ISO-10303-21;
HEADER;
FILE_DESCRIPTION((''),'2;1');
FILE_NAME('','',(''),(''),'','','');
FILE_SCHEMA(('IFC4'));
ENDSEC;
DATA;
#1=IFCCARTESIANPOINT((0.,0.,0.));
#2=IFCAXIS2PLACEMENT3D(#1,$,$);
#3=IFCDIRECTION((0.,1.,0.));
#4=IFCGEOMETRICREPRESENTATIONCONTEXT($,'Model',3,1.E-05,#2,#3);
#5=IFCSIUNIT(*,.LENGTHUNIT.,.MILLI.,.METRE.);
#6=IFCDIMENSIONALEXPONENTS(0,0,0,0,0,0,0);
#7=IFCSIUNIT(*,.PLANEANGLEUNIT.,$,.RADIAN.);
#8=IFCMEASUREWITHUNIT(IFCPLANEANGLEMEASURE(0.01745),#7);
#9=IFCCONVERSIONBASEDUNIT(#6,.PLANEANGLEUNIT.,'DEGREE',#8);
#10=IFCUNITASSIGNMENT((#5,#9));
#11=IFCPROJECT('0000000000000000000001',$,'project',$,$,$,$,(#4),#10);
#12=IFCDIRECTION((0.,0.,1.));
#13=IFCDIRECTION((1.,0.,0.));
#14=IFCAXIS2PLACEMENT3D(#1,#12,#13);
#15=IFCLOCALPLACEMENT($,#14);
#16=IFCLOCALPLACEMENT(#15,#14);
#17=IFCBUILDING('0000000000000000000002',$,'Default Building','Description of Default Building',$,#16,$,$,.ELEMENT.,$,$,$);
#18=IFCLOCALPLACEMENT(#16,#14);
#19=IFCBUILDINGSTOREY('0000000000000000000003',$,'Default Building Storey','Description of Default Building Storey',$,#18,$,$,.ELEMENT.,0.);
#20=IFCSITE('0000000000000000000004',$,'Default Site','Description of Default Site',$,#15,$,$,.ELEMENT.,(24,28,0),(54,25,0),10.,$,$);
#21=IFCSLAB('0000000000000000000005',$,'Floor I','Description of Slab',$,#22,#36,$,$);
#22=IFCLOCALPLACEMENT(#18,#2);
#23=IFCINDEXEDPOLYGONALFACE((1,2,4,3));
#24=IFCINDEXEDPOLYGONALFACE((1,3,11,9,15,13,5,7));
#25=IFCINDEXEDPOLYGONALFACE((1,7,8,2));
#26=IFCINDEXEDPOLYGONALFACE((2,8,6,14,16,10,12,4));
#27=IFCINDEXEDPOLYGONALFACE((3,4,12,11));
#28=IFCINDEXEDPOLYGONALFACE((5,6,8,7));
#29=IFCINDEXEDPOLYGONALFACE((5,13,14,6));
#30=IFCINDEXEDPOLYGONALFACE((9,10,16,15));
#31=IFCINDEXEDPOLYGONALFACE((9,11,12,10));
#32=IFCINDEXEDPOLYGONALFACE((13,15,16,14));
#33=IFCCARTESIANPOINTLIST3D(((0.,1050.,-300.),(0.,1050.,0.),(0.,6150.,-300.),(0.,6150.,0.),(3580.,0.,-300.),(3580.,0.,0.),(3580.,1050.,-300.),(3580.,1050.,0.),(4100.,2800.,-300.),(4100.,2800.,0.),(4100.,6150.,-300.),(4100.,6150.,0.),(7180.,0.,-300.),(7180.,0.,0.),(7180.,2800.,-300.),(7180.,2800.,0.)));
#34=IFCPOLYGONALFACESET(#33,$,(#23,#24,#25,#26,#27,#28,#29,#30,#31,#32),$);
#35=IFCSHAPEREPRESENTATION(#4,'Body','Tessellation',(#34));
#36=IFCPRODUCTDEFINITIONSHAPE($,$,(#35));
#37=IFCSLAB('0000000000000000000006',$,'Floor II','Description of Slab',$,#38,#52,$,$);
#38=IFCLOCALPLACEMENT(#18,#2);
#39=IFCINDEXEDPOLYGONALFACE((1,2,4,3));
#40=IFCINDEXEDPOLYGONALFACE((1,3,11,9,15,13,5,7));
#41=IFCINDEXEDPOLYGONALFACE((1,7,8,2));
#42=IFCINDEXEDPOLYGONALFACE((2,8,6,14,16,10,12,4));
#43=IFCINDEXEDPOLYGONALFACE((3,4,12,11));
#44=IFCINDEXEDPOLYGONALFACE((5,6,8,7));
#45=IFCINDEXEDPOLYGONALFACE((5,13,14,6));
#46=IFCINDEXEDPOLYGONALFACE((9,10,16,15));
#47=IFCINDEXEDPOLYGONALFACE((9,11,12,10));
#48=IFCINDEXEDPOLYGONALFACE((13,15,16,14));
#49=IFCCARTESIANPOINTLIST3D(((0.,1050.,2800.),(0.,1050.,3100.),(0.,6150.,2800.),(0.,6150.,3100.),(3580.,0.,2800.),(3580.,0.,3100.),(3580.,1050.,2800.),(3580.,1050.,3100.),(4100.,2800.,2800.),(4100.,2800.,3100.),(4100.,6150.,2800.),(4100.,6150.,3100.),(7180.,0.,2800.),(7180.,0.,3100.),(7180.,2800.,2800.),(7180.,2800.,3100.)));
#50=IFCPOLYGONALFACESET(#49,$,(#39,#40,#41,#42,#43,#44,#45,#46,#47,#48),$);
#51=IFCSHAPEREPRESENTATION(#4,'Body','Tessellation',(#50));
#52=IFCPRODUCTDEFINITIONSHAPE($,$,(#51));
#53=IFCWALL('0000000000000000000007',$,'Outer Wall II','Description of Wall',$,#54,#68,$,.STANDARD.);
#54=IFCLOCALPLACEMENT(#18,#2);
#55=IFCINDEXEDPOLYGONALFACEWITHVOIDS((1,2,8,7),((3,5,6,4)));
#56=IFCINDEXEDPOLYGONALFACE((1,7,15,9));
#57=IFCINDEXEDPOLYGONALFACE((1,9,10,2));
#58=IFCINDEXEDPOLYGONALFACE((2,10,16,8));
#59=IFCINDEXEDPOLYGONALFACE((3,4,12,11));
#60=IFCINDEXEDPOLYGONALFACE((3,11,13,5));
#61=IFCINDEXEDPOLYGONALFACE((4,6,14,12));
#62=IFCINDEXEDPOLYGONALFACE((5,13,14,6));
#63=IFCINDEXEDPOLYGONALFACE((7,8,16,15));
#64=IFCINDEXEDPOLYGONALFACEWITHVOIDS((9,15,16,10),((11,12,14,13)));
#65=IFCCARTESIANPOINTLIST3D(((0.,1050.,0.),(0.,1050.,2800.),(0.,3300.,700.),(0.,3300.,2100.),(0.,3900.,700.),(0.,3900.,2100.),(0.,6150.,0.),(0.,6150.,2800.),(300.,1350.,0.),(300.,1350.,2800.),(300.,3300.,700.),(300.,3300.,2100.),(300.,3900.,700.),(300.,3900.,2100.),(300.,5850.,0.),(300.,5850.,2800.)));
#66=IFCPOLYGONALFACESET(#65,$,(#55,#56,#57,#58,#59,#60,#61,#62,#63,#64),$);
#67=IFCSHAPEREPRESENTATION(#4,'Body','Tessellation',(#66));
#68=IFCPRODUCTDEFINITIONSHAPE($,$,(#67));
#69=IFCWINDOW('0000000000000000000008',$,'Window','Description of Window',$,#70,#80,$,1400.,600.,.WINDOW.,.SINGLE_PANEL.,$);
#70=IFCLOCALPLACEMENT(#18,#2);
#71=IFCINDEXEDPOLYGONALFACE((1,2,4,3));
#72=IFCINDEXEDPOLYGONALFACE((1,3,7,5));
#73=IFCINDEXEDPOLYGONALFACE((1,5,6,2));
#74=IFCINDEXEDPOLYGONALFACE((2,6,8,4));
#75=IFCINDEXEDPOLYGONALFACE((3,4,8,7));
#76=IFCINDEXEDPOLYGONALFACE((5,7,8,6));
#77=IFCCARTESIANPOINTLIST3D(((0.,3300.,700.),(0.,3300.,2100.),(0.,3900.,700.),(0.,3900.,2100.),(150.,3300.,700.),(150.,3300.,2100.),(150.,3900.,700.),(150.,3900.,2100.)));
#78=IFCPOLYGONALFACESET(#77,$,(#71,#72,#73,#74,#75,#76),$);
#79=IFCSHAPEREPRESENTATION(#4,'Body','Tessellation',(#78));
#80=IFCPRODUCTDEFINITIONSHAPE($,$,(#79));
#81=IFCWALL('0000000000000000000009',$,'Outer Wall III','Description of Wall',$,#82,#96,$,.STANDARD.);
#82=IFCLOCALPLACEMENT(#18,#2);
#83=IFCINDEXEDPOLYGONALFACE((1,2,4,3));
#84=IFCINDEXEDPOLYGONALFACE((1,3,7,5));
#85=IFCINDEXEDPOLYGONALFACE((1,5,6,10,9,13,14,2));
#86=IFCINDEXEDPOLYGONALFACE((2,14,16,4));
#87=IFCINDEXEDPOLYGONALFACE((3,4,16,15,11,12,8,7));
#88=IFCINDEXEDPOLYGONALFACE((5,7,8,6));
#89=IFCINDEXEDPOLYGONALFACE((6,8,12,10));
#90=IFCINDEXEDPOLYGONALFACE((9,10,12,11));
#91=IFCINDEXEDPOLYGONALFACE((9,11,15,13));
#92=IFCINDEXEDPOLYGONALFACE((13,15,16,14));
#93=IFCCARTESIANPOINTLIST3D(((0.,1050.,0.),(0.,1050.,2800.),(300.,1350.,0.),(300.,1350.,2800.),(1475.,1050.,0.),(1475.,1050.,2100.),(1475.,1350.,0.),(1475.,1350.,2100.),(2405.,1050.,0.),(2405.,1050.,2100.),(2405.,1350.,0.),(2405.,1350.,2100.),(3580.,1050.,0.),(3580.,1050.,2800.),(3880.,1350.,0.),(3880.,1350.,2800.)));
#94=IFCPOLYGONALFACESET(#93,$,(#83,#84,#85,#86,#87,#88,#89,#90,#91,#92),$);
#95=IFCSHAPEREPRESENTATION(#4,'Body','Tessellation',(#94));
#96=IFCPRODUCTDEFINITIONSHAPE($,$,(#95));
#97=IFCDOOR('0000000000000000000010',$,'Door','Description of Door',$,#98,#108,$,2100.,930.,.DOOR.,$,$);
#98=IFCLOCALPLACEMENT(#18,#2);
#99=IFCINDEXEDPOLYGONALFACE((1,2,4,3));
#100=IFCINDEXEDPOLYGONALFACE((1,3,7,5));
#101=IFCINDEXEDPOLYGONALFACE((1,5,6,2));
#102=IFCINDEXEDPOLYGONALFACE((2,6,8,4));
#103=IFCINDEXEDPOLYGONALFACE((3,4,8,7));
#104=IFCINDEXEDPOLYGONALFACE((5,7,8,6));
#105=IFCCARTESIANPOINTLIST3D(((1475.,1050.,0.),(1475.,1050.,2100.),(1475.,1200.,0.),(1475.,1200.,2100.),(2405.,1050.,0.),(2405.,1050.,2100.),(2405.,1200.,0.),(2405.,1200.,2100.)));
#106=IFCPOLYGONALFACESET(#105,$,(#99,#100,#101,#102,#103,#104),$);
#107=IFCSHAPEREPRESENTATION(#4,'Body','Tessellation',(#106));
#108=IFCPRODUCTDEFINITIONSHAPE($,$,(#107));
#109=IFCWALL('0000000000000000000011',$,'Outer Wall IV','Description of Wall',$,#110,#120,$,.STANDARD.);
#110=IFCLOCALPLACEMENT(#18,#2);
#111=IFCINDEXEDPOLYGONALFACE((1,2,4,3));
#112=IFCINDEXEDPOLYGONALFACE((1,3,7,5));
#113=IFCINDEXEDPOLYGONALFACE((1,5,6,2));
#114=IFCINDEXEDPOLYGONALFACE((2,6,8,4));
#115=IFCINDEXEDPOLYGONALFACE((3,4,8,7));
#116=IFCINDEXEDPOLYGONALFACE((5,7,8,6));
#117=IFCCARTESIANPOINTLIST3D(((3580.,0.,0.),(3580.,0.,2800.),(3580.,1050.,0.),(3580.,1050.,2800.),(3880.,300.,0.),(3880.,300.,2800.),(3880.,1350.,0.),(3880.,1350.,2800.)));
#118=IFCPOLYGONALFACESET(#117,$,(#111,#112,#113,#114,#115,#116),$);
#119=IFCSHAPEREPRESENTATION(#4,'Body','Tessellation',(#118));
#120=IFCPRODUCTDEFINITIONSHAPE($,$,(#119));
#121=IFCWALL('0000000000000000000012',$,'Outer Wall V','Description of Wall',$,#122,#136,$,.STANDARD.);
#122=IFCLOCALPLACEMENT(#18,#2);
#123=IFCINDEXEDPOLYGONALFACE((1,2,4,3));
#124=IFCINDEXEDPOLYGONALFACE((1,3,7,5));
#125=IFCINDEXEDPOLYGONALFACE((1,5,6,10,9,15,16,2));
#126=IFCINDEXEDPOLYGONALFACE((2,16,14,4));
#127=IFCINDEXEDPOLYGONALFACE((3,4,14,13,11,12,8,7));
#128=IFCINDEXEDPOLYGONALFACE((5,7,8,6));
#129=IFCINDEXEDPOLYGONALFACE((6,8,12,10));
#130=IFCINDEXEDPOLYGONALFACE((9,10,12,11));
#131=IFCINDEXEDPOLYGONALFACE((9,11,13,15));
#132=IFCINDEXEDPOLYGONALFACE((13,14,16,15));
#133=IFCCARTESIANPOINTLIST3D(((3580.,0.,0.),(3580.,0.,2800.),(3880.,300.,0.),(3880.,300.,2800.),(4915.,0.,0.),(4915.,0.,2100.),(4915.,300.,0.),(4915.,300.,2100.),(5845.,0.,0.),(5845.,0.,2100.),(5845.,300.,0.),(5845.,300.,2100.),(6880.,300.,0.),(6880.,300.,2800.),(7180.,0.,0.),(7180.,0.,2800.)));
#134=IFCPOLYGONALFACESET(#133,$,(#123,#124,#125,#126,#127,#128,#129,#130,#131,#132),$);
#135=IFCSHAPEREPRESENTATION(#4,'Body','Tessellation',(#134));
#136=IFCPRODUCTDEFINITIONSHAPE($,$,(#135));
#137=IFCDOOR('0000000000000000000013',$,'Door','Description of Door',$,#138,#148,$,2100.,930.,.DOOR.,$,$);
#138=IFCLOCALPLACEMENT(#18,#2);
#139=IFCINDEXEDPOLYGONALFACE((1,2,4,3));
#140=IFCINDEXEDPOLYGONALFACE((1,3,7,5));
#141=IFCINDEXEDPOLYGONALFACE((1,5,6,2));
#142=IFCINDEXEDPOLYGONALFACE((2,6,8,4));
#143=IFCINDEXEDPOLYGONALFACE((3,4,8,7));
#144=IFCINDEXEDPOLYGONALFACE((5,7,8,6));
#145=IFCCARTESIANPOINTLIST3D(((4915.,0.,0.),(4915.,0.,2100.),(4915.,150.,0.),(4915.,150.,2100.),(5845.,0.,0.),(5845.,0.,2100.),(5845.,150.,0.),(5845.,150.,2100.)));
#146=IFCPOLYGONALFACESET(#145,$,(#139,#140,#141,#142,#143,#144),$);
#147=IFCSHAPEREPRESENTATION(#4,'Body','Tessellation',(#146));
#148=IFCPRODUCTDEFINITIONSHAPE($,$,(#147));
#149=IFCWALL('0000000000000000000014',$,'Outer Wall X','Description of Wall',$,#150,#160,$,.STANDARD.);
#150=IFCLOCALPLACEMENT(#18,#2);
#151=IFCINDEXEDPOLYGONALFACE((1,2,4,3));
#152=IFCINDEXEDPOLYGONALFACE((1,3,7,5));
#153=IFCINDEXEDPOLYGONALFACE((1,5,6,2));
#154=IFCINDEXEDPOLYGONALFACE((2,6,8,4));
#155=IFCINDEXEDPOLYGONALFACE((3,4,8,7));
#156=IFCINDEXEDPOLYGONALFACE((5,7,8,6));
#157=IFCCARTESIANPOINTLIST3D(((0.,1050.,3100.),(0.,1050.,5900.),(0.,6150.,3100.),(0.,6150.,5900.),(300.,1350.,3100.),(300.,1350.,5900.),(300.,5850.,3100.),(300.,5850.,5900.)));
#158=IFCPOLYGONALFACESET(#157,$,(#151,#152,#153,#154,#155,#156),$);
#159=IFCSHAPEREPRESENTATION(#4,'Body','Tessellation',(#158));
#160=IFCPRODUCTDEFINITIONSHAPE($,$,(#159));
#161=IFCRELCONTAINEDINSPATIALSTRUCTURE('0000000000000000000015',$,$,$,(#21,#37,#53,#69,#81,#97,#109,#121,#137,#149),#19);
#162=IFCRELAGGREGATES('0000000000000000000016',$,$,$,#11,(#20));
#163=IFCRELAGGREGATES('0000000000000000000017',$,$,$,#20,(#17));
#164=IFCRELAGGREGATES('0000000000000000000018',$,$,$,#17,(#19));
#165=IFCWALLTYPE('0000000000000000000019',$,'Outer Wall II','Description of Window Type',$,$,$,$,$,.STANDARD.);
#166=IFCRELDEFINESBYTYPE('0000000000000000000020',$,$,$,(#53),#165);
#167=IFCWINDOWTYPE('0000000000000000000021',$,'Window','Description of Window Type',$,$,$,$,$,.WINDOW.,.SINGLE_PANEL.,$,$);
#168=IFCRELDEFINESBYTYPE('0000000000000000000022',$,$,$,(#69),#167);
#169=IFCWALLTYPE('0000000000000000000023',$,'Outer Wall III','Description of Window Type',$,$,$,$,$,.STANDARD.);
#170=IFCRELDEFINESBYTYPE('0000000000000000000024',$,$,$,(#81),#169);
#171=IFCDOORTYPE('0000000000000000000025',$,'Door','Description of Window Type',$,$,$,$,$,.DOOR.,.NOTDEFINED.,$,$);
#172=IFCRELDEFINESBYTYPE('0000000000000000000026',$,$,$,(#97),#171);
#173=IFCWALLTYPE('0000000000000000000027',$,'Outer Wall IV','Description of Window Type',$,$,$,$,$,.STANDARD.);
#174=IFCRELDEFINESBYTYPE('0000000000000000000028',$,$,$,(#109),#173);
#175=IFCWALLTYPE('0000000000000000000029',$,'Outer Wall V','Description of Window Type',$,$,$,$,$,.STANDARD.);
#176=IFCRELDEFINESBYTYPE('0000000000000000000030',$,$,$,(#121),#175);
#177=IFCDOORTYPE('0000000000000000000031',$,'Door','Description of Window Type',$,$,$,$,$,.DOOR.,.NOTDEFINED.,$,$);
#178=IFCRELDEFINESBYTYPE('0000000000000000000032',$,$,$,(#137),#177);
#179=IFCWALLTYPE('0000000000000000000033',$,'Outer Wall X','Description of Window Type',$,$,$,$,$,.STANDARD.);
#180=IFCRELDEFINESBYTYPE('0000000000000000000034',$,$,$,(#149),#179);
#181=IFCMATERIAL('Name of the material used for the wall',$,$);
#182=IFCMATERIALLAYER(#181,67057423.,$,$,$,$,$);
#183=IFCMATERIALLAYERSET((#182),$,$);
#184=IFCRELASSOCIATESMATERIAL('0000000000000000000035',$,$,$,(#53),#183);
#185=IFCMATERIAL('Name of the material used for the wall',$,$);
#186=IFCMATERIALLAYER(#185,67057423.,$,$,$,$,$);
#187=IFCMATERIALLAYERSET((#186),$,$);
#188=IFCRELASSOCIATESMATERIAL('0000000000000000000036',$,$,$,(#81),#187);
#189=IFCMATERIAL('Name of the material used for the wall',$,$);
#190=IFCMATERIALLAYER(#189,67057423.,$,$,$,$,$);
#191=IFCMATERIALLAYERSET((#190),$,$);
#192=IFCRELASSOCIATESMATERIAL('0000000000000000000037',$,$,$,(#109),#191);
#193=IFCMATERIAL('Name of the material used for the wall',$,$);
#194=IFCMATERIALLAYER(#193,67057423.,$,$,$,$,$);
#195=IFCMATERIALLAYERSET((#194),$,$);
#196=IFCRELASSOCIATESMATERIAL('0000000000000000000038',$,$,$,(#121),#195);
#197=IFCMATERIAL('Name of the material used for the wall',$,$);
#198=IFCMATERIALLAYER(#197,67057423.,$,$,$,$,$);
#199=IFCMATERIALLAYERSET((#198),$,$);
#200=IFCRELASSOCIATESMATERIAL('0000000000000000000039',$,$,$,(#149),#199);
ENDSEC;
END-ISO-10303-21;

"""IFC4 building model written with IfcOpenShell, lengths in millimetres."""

from ifc_helpers import new_model, entity, si_unit, converted_unit, direction, frame, origin, origin_with_axes, place, context, project, spatial, polyline, outline, extrude, material, layer, layer_set, layer_usage, type_object, element, fill, save


model = new_model("IFC4")

# Units and contexts
model_context = context("Model", 3, precision=1e-05, world=origin(), true_north=direction((0.0, 1.0, 0.0)))
ifc_project = project(units=[si_unit("LENGTHUNIT", "METRE", prefix="MILLI"), converted_unit("PLANEANGLEUNIT", "DEGREE", entity("IfcPlaneAngleMeasure", 0.01745), si_unit("PLANEANGLEUNIT", "RADIAN"), dimensions=[0, 0, 0, 0, 0, 0, 0])], contexts=[model_context])

# Site, building, storey
site_placement = place(None, origin_with_axes())
site = spatial("IfcSite", under=ifc_project, at=site_placement, Name="Default Site", Description="Description of Default Site", CompositionType="ELEMENT", RefLatitude=(24, 28, 0), RefLongitude=(54, 25, 0), RefElevation=10.0)
building_placement = place(site_placement, origin_with_axes())
building = spatial("IfcBuilding", under=site, at=building_placement, Name="Default Building", Description="Description of Default Building", CompositionType="ELEMENT")
storey_placement = place(building_placement, origin_with_axes())
storey = spatial("IfcBuildingStorey", under=building, at=storey_placement, Name="Default Building Storey", Description="Description of Default Building Storey", CompositionType="ELEMENT", Elevation=0.0)

# Slabs
for number, where, z_axis, x_axis, name in (
    (1, (0.0, 0.0, -300.0), (0.0, 0.0, 1.0), (1.0, 0.0, 0.0), "Floor I"),
    (2, (0.0, 0.0, 2800.0), (0.0, 0.0, 1.0), (1.0, 0.0, 0.0), "Floor II"),
):
    element("IfcSlab", number, at=place(storey_placement, frame(where, z_axis=z_axis, x_axis=x_axis)), inside=storey, Name=name, Description="Description of Slab", context=model_context, shape_type="SweptSolid", body=[
        extrude(outline(polyline([(0.0, 1050.0), (0.0, 6150.0), (4100.0, 6150.0), (4100.0, 2800.0), (7180.0, 2800.0), (7180.0, 0.0), (3580.0, 0.0), (3580.0, 1050.0), (0.0, 1050.0)])), origin_with_axes(), (0.0, 0.0, 1.0), 300.0),
    ])

# Wall, opening, window
ifc_material_1 = material(Name="Name of the material used for the wall")
ifc_layer_1 = layer(ifc_material_1, 67057423.0)
ifc_layer_set_1 = layer_set([ifc_layer_1])
ifc_layer_usage_1 = layer_usage(ifc_layer_set_1, "AXIS2", "POSITIVE", -33528711.5)
wall_type_1 = type_object("IfcWallType", Name="Outer Wall II", Description="Description of Window Type", PredefinedType="STANDARD")
wall_1_placement = place(storey_placement, frame((150.0, 6000.0, 0.0), z_axis=(0.0, 0.0, 1.0), x_axis=(0.0, -1.0, 0.0)))
wall_1 = element("IfcWall", 3, at=wall_1_placement, inside=storey, type_object=wall_type_1, material=ifc_layer_usage_1, Name="Outer Wall II", Description="Description of Wall", PredefinedType="STANDARD", context=model_context, shape_type="SweptSolid", body=[
    extrude(outline(polyline([(-150.0, -150.0), (150.0, 150.0), (4650.0, 150.0), (4950.0, -150.0), (-150.0, -150.0)])), origin_with_axes(), (0.0, 0.0, 1.0), 2800.0),
])
opening_1_placement = place(wall_1_placement, frame((2100.0, -150.0, 700.0), z_axis=(0.0, 0.0, 1.0), x_axis=(1.0, 0.0, 0.0)))
opening_1 = element("IfcOpeningElement", 4, at=opening_1_placement, cuts=wall_1, context=model_context, shape_type="SweptSolid", body=[
    extrude(outline(polyline([(0.0, 0.0), (0.0, 300.0), (600.0, 300.0), (600.0, 0.0), (0.0, 0.0)])), origin_with_axes(), (0.0, 0.0, 1.0), 1400.0),
])
window_type_1 = type_object("IfcWindowType", Name="Window", Description="Description of Window Type", PartitioningType="SINGLE_PANEL", PredefinedType="WINDOW")
window_1_placement = place(opening_1_placement, origin_with_axes())
window_1 = element("IfcWindow", 5, at=window_1_placement, inside=storey, type_object=window_type_1, Name="Window", Description="Description of Window", OverallHeight=1400.0, OverallWidth=600.0, PartitioningType="SINGLE_PANEL", PredefinedType="WINDOW", context=model_context, shape_type="SweptSolid", body=[
    extrude(outline(polyline([(0.0, 0.0), (0.0, 150.0), (600.0, 150.0), (600.0, 0.0), (0.0, 0.0)])), origin_with_axes(), (0.0, 0.0, 1.0), 1400.0),
])
fill(opening_1, window_1)

# Wall, opening, door
ifc_material_2 = material(Name="Name of the material used for the wall")
ifc_layer_2 = layer(ifc_material_2, 67057423.0)
ifc_layer_set_2 = layer_set([ifc_layer_2])
ifc_layer_usage_2 = layer_usage(ifc_layer_set_2, "AXIS2", "POSITIVE", -33528711.5)
wall_type_2 = type_object("IfcWallType", Name="Outer Wall III", Description="Description of Window Type", PredefinedType="STANDARD")
wall_2_placement = place(storey_placement, frame((150.0, 1200.0, 0.0), z_axis=(0.0, 0.0, 1.0), x_axis=(1.0, 0.0, 0.0)))
wall_2 = element("IfcWall", 6, at=wall_2_placement, inside=storey, type_object=wall_type_2, material=ifc_layer_usage_2, Name="Outer Wall III", Description="Description of Wall", PredefinedType="STANDARD", context=model_context, shape_type="SweptSolid", body=[
    extrude(outline(polyline([(-150.0, -150.0), (150.0, 150.0), (3730.0, 150.0), (3430.0, -150.0), (-150.0, -150.0)])), origin_with_axes(), (0.0, 0.0, 1.0), 2800.0),
])
opening_2_placement = place(wall_2_placement, frame((1325.0, -150.0, 0.0), z_axis=(0.0, 0.0, 1.0), x_axis=(1.0, 0.0, 0.0)))
opening_2 = element("IfcOpeningElement", 7, at=opening_2_placement, cuts=wall_2, context=model_context, shape_type="SweptSolid", body=[
    extrude(outline(polyline([(0.0, 0.0), (0.0, 300.0), (930.0, 300.0), (930.0, 0.0), (0.0, 0.0)])), origin_with_axes(), (0.0, 0.0, 1.0), 2100.0),
])
door_type_1 = type_object("IfcDoorType", Name="Door", Description="Description of Window Type", PredefinedType="DOOR")
door_1_placement = place(opening_2_placement, origin_with_axes())
door_1 = element("IfcDoor", 8, at=door_1_placement, inside=storey, type_object=door_type_1, Name="Door", Description="Description of Door", OverallHeight=2100.0, OverallWidth=930.0, PredefinedType="DOOR", context=model_context, shape_type="SweptSolid", body=[
    extrude(outline(polyline([(0.0, 0.0), (0.0, 150.0), (930.0, 150.0), (930.0, 0.0), (0.0, 0.0)])), origin_with_axes(), (0.0, 0.0, 1.0), 2100.0),
])
fill(opening_2, door_1)

# Wall
ifc_material_3 = material(Name="Name of the material used for the wall")
ifc_layer_3 = layer(ifc_material_3, 67057423.0)
ifc_layer_set_3 = layer_set([ifc_layer_3])
ifc_layer_usage_3 = layer_usage(ifc_layer_set_3, "AXIS2", "POSITIVE", -33528711.5)
wall_type_3 = type_object("IfcWallType", Name="Outer Wall IV", Description="Description of Window Type", PredefinedType="STANDARD")
wall_3_placement = place(storey_placement, frame((3730.0, 1200.0, 0.0), z_axis=(0.0, 0.0, 1.0), x_axis=(0.0, -1.0, 0.0)))
element("IfcWall", 9, at=wall_3_placement, inside=storey, type_object=wall_type_3, material=ifc_layer_usage_3, Name="Outer Wall IV", Description="Description of Wall", PredefinedType="STANDARD", context=model_context, shape_type="SweptSolid", body=[
    extrude(outline(polyline([(150.0, -150.0), (-150.0, 150.0), (900.0, 150.0), (1200.0, -150.0), (150.0, -150.0)])), origin_with_axes(), (0.0, 0.0, 1.0), 2800.0),
])

# Wall, opening, door
ifc_material_4 = material(Name="Name of the material used for the wall")
ifc_layer_4 = layer(ifc_material_4, 67057423.0)
ifc_layer_set_4 = layer_set([ifc_layer_4])
ifc_layer_usage_4 = layer_usage(ifc_layer_set_4, "AXIS2", "POSITIVE", -33528711.5)
wall_type_4 = type_object("IfcWallType", Name="Outer Wall V", Description="Description of Window Type", PredefinedType="STANDARD")
wall_4_placement = place(storey_placement, frame((3730.0, 150.0, 0.0), z_axis=(0.0, 0.0, 1.0), x_axis=(1.0, 0.0, 0.0)))
wall_4 = element("IfcWall", 10, at=wall_4_placement, inside=storey, type_object=wall_type_4, material=ifc_layer_usage_4, Name="Outer Wall V", Description="Description of Wall", PredefinedType="STANDARD", context=model_context, shape_type="SweptSolid", body=[
    extrude(outline(polyline([(-150.0, -150.0), (150.0, 150.0), (3150.0, 150.0), (3450.0, -150.0), (-150.0, -150.0)])), origin_with_axes(), (0.0, 0.0, 1.0), 2800.0),
])
opening_3_placement = place(wall_4_placement, frame((1185.0, -150.0, 0.0), z_axis=(0.0, 0.0, 1.0), x_axis=(1.0, 0.0, 0.0)))
opening_3 = element("IfcOpeningElement", 11, at=opening_3_placement, cuts=wall_4, context=model_context, shape_type="SweptSolid", body=[
    extrude(outline(polyline([(0.0, 0.0), (0.0, 300.0), (930.0, 300.0), (930.0, 0.0), (0.0, 0.0)])), origin_with_axes(), (0.0, 0.0, 1.0), 2100.0),
])
door_type_2 = type_object("IfcDoorType", Name="Door", Description="Description of Window Type", PredefinedType="DOOR")
door_2_placement = place(opening_3_placement, origin_with_axes())
door_2 = element("IfcDoor", 12, at=door_2_placement, inside=storey, type_object=door_type_2, Name="Door", Description="Description of Door", OverallHeight=2100.0, OverallWidth=930.0, PredefinedType="DOOR", context=model_context, shape_type="SweptSolid", body=[
    extrude(outline(polyline([(0.0, 0.0), (0.0, 150.0), (930.0, 150.0), (930.0, 0.0), (0.0, 0.0)])), origin_with_axes(), (0.0, 0.0, 1.0), 2100.0),
])
fill(opening_3, door_2)

# Wall
ifc_material_5 = material(Name="Name of the material used for the wall")
ifc_layer_5 = layer(ifc_material_5, 67057423.0)
ifc_layer_set_5 = layer_set([ifc_layer_5])
ifc_layer_usage_5 = layer_usage(ifc_layer_set_5, "AXIS2", "POSITIVE", -33528711.5)
wall_type_5 = type_object("IfcWallType", Name="Outer Wall X", Description="Description of Window Type", PredefinedType="STANDARD")
wall_5_placement = place(storey_placement, frame((150.0, 6000.0, 3100.0), z_axis=(0.0, 0.0, 1.0), x_axis=(0.0, -1.0, 0.0)))
element("IfcWall", 13, at=wall_5_placement, inside=storey, type_object=wall_type_5, material=ifc_layer_usage_5, Name="Outer Wall X", Description="Description of Wall", PredefinedType="STANDARD", context=model_context, shape_type="SweptSolid", body=[
    extrude(outline(polyline([(-150.0, -150.0), (150.0, 150.0), (4650.0, 150.0), (4950.0, -150.0), (-150.0, -150.0)])), origin_with_axes(), (0.0, 0.0, 1.0), 2800.0),
])

save(model, "model.ifc")
